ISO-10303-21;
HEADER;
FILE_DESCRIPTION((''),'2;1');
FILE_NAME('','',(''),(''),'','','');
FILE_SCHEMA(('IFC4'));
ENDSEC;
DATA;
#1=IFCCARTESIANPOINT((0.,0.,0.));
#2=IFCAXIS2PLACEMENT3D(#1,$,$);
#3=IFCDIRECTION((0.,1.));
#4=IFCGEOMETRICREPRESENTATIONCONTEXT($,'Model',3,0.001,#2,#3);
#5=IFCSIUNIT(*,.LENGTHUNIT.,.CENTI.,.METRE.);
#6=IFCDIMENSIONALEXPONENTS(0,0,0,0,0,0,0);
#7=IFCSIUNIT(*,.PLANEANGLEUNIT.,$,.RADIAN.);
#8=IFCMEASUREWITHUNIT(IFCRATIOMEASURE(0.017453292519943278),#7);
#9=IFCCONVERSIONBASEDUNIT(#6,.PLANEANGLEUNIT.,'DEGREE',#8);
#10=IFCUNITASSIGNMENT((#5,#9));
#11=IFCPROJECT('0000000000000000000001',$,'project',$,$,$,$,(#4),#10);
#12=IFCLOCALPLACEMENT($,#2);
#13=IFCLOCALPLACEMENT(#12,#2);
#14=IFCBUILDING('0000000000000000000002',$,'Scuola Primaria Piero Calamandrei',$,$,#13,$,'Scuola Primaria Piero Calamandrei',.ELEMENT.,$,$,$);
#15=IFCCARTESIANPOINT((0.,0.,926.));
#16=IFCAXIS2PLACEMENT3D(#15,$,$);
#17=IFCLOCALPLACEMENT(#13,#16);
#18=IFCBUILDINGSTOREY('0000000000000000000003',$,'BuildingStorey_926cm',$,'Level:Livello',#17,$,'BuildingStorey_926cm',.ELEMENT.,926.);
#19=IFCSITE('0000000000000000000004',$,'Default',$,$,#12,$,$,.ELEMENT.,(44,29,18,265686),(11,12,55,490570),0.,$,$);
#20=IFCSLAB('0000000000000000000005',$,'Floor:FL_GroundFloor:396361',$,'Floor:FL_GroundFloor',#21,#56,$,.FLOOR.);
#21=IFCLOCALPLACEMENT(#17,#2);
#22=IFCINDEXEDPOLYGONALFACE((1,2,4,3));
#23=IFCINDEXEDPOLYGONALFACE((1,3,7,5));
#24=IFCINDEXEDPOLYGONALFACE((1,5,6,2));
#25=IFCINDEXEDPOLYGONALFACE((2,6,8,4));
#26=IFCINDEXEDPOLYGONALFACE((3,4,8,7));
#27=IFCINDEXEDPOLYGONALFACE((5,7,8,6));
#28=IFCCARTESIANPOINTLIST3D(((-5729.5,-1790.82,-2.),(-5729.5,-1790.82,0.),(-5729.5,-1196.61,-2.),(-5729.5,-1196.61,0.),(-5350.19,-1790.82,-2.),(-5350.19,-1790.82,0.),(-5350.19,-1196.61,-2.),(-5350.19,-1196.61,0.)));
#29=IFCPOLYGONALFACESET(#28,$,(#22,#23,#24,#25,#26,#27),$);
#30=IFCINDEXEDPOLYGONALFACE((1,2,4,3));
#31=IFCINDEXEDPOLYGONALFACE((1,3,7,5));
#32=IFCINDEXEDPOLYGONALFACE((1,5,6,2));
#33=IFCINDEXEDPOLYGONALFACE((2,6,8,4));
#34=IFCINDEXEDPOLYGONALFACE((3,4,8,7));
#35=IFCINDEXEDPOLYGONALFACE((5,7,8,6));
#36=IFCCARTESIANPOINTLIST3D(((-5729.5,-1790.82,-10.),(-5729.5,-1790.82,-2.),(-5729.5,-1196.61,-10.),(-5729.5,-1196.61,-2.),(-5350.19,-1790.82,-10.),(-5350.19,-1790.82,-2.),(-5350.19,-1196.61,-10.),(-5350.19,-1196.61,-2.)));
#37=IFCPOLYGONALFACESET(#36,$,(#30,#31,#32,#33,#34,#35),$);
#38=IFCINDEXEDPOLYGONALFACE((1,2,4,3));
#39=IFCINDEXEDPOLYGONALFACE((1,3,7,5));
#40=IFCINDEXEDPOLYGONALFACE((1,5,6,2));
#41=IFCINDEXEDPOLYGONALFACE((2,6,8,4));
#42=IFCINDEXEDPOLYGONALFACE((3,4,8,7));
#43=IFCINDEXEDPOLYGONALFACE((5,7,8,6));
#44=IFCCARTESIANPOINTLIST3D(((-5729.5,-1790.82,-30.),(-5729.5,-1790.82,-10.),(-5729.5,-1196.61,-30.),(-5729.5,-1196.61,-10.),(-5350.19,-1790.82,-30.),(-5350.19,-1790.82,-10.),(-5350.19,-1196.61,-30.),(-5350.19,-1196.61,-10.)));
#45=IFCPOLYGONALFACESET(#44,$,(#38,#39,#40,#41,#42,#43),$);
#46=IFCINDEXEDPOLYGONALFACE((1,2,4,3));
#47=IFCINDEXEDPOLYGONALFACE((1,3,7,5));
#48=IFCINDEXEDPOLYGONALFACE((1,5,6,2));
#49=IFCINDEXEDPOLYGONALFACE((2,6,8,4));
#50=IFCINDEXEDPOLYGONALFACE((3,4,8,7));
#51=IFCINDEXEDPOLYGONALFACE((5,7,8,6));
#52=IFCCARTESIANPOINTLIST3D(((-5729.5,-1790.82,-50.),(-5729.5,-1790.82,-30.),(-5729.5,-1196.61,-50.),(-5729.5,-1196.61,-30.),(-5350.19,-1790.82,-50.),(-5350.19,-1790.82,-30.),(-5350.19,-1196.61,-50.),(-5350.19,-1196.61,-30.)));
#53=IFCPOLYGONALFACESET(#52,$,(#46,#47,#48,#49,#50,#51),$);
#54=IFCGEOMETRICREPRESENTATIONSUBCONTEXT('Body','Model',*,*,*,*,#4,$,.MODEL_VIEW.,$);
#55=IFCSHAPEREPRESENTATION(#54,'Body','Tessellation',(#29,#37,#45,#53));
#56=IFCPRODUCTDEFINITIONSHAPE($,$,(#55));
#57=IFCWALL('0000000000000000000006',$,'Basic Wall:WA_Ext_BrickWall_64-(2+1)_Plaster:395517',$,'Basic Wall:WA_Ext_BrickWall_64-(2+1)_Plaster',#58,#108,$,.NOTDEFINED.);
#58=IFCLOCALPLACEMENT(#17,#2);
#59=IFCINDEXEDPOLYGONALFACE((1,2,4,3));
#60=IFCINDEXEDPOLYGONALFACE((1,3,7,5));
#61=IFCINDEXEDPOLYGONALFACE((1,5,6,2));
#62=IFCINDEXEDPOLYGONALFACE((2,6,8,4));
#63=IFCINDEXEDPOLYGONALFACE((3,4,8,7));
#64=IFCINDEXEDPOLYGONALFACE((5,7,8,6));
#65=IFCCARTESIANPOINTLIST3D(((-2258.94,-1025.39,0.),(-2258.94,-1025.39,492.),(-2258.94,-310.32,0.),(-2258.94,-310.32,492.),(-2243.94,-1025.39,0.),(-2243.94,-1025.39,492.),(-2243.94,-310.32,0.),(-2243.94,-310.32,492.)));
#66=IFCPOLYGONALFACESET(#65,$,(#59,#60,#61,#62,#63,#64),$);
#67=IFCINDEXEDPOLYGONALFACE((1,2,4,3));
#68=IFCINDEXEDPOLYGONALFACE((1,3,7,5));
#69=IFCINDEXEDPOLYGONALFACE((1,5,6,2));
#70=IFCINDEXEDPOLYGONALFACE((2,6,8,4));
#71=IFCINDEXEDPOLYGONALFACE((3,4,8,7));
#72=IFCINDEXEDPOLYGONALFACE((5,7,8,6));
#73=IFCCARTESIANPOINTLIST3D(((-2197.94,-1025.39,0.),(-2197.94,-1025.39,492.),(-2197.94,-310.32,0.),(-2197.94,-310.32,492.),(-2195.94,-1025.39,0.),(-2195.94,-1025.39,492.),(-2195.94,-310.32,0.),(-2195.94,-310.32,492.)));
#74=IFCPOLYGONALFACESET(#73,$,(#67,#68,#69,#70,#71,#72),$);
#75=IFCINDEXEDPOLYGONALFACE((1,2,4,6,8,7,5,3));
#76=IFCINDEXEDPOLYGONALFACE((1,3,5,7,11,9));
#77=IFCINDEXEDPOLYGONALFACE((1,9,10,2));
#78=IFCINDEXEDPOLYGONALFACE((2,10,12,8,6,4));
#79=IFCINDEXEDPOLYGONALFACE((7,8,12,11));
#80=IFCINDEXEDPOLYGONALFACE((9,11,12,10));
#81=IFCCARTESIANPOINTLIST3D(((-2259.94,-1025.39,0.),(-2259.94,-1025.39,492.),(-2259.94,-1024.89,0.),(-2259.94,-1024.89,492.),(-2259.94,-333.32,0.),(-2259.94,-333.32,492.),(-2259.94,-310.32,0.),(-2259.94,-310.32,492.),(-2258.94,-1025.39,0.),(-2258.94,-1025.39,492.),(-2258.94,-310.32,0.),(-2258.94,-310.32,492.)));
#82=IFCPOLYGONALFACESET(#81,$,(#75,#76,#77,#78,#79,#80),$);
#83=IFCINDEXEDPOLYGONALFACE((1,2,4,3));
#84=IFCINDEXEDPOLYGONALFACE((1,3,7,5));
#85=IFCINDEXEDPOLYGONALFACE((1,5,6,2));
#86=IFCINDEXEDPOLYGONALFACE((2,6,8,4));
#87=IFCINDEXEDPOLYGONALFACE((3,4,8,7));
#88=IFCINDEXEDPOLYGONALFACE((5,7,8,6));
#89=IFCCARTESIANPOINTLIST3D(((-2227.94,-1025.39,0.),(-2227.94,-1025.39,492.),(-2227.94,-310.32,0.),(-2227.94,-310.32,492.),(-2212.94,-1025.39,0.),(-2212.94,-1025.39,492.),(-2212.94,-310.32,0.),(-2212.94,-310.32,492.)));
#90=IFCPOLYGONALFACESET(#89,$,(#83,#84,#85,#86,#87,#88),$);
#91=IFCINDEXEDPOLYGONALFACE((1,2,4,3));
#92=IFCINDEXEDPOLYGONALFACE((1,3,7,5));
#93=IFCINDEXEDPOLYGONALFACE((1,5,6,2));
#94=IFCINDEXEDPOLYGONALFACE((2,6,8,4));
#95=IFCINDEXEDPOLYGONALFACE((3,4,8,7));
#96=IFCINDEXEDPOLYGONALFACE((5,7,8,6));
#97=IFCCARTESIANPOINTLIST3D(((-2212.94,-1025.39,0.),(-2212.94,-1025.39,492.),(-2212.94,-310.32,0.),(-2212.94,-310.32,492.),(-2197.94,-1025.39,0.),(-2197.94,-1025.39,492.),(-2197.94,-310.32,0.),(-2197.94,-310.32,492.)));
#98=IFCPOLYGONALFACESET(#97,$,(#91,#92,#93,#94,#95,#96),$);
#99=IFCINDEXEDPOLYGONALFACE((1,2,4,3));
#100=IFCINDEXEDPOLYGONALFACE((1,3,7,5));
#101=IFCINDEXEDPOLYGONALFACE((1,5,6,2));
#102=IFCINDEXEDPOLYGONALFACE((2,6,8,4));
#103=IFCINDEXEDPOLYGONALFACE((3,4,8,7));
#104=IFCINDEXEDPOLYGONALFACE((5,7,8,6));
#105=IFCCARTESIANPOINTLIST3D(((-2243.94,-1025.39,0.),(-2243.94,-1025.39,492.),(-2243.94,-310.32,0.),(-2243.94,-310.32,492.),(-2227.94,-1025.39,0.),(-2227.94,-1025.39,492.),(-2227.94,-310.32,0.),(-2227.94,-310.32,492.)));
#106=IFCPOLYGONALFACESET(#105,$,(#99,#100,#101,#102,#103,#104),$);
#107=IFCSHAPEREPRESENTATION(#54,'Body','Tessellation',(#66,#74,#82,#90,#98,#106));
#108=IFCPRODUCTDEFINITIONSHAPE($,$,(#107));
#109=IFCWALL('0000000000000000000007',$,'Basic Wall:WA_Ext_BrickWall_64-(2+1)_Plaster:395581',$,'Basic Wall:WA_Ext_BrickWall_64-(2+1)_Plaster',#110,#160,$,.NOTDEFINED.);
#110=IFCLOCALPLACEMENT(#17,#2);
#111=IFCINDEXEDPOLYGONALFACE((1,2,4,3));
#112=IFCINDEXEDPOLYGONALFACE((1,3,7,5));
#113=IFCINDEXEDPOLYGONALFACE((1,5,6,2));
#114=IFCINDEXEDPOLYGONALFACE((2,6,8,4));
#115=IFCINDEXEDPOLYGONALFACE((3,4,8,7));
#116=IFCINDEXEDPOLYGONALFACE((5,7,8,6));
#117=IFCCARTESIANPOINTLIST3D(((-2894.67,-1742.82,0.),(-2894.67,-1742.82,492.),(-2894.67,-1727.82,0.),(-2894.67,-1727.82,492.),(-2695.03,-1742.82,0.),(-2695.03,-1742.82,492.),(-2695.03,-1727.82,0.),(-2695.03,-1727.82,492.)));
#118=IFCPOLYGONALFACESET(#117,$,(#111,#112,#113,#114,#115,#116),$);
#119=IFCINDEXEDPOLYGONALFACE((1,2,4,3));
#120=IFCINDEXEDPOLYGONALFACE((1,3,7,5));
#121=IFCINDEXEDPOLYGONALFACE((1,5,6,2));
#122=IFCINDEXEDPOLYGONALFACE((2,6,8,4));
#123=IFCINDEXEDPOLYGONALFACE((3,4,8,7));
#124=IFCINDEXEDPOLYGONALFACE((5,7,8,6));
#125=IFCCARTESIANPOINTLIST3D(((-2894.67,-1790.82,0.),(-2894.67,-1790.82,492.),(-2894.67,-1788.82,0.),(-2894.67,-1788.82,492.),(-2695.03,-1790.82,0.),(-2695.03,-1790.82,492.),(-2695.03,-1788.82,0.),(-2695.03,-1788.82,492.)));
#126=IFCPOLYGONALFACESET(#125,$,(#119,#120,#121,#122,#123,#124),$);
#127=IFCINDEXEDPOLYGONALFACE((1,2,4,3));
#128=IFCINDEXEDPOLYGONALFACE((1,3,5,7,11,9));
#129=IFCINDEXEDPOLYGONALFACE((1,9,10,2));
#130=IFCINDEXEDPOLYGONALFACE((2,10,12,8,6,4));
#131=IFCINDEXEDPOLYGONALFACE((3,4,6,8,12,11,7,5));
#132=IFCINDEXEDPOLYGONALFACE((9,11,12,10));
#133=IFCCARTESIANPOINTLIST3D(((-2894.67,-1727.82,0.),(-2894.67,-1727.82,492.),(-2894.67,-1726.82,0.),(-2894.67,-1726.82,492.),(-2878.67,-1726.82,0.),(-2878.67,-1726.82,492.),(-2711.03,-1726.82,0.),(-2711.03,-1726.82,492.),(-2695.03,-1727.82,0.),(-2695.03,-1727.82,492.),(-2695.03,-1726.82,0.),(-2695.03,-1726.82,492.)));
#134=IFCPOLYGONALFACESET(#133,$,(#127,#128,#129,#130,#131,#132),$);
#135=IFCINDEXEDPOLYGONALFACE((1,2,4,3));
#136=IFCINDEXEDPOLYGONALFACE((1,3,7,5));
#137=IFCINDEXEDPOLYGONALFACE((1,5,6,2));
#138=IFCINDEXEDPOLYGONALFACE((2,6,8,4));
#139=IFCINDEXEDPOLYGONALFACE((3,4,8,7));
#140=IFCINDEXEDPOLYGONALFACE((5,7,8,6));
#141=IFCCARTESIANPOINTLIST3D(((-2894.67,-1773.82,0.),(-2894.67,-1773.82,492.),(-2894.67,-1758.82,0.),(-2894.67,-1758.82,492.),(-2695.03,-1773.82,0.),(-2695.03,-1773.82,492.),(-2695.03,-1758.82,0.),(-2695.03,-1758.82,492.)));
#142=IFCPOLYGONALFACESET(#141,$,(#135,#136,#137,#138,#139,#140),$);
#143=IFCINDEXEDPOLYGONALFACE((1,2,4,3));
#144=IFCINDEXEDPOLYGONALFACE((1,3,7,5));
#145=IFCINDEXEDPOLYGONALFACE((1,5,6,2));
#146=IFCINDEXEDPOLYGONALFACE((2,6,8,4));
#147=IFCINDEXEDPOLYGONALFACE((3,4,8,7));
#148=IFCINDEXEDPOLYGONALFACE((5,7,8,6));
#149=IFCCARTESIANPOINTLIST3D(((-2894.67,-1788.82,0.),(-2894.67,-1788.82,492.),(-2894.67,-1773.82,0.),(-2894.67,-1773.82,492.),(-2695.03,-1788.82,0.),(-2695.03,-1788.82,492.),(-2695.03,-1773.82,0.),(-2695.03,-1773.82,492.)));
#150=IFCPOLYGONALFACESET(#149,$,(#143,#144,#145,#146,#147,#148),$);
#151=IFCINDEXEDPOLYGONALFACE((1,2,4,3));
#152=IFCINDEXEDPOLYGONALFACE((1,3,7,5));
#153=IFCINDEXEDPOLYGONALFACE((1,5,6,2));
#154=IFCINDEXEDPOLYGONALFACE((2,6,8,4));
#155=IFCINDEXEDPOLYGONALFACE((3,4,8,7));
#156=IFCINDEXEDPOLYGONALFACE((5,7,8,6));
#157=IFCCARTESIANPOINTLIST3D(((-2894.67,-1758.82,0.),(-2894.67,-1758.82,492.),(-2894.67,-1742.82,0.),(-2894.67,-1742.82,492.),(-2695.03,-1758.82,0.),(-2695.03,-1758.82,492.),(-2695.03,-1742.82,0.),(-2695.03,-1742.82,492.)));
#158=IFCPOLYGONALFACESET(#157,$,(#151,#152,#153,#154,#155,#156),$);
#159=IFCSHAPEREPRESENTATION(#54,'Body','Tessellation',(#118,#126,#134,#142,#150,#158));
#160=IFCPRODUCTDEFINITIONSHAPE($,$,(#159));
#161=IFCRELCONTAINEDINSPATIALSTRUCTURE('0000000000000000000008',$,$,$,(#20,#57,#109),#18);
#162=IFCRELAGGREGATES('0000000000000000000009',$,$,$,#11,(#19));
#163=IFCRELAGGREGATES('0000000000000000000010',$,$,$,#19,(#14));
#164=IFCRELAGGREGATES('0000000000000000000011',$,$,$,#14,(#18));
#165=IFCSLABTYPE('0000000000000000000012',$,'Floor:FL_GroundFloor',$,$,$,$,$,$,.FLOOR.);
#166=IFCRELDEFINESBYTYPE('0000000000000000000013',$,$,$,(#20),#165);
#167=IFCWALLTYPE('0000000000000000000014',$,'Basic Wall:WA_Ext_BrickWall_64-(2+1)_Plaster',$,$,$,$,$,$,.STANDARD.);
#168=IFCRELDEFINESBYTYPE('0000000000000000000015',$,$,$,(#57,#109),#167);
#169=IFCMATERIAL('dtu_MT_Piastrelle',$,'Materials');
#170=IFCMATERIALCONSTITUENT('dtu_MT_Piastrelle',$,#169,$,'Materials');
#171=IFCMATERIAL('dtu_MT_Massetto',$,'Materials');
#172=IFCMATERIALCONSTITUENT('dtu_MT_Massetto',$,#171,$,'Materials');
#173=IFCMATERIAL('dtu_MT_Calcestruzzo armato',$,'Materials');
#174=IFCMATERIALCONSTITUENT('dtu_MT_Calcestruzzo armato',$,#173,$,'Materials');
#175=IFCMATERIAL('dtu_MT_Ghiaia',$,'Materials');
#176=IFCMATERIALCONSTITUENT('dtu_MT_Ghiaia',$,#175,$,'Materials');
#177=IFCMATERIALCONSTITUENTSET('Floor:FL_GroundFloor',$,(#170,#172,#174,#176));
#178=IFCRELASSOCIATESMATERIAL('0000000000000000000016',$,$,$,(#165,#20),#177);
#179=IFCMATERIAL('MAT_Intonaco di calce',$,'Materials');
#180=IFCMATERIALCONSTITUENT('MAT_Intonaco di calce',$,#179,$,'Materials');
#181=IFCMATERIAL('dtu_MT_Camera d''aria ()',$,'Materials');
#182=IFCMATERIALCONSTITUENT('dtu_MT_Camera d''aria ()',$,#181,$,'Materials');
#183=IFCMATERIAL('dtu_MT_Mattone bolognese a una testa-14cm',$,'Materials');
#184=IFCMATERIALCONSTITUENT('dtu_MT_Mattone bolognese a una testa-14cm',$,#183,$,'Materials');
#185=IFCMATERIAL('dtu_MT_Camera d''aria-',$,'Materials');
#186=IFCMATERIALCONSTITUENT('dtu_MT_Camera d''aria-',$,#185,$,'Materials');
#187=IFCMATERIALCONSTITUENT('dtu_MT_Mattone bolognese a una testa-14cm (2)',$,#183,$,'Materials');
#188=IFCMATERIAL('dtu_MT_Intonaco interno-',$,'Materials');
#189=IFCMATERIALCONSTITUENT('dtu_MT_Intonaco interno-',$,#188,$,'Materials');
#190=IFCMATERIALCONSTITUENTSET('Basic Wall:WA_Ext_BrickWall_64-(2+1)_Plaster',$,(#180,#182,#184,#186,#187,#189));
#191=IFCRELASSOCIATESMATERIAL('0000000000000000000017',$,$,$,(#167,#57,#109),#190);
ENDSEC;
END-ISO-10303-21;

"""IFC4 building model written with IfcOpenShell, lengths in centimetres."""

from ifc_helpers import new_model, entity, si_unit, converted_unit, direction, frame, origin, place, context, subcontext, project, spatial, indexed_curve, outline, extrude, material, constituent, constituent_set, type_object, element, save


model = new_model("IFC4")

# Units and contexts
model_context = context("Model", 3, precision=0.001, world=origin(), true_north=direction((0.0, 1.0)))
body_context = subcontext(model_context, "Body", "Model", "MODEL_VIEW")
ifc_project = project(units=[si_unit("LENGTHUNIT", "METRE", prefix="CENTI"), converted_unit("PLANEANGLEUNIT", "DEGREE", entity("IfcRatioMeasure", 0.017453292519943278), si_unit("PLANEANGLEUNIT", "RADIAN"), dimensions=[0, 0, 0, 0, 0, 0, 0])], contexts=[model_context])

# Site, building, storey
site_placement = place(None, origin())
site = spatial("IfcSite", under=ifc_project, at=site_placement, Name="Default", CompositionType="ELEMENT", RefLatitude=(44, 29, 18, 265686), RefLongitude=(11, 12, 55, 490570), RefElevation=0.0)
building_placement = place(site_placement, origin())
building = spatial("IfcBuilding", under=site, at=building_placement, Name="Scuola Primaria Piero Calamandrei", LongName="Scuola Primaria Piero Calamandrei", CompositionType="ELEMENT")
storey_placement = place(building_placement, frame((0.0, 0.0, 926.0)))
storey = spatial("IfcBuildingStorey", under=building, at=storey_placement, Name="BuildingStorey_926cm", ObjectType="Level:Livello", LongName="BuildingStorey_926cm", CompositionType="ELEMENT", Elevation=926.0)

# Slab
ifc_material_1 = material(Name="dtu_MT_Piastrelle", Category="Materials")
ifc_constituent_1 = constituent(ifc_material_1, Name="dtu_MT_Piastrelle", Category="Materials")
ifc_material_2 = material(Name="dtu_MT_Massetto", Category="Materials")
ifc_constituent_2 = constituent(ifc_material_2, Name="dtu_MT_Massetto", Category="Materials")
ifc_material_3 = material(Name="dtu_MT_Calcestruzzo armato", Category="Materials")
ifc_constituent_3 = constituent(ifc_material_3, Name="dtu_MT_Calcestruzzo armato", Category="Materials")
ifc_material_4 = material(Name="dtu_MT_Ghiaia", Category="Materials")
ifc_constituent_4 = constituent(ifc_material_4, Name="dtu_MT_Ghiaia", Category="Materials")
ifc_constituent_set_1 = constituent_set(constituents=[ifc_constituent_1, ifc_constituent_2, ifc_constituent_3, ifc_constituent_4], Name="Floor:FL_GroundFloor")
slab_type_1 = type_object("IfcSlabType", Name="Floor:FL_GroundFloor", PredefinedType="FLOOR", material=ifc_constituent_set_1)
slab_1_placement = place(storey_placement, origin())
element("IfcSlab", 1, at=slab_1_placement, inside=storey, type_object=slab_type_1, material=ifc_constituent_set_1, Name="Floor:FL_GroundFloor:396361", ObjectType="Floor:FL_GroundFloor", PredefinedType="FLOOR", context=body_context, shape_type="SweptSolid", body=[
    extrude(outline(indexed_curve([(-297.11, -189.65), (297.11, -189.65), (297.11, 189.65), (-297.11, 189.65), (-297.11, -189.65)], self_intersect=False)), frame((-5539.85, -1493.71, -2.0), z_axis=(0.0, 0.0, 1.0), x_axis=(0.0, 1.0, 0.0)), (0.0, 0.0, 1.0), 2.0),
    extrude(outline(indexed_curve([(-297.11, -189.65), (297.11, -189.65), (297.11, 189.65), (-297.11, 189.65), (-297.11, -189.65)], self_intersect=False)), frame((-5539.85, -1493.71, -10.0), z_axis=(0.0, 0.0, 1.0), x_axis=(0.0, 1.0, 0.0)), (0.0, 0.0, 1.0), 8.0),
    extrude(outline(indexed_curve([(-297.11, -189.65), (297.11, -189.65), (297.11, 189.65), (-297.11, 189.65), (-297.11, -189.65)], self_intersect=False)), frame((-5539.85, -1493.71, -30.0), z_axis=(0.0, 0.0, 1.0), x_axis=(0.0, 1.0, 0.0)), (0.0, 0.0, 1.0), 20.0),
    extrude(outline(indexed_curve([(-297.11, -189.65), (297.11, -189.65), (297.11, 189.65), (-297.11, 189.65), (-297.11, -189.65)], self_intersect=False)), frame((-5539.85, -1493.71, -50.0), z_axis=(0.0, 0.0, 1.0), x_axis=(0.0, 1.0, 0.0)), (0.0, 0.0, 1.0), 20.0),
])

# Walls
ifc_material_5 = material(Name="MAT_Intonaco di calce", Category="Materials")
ifc_constituent_5 = constituent(ifc_material_5, Name="MAT_Intonaco di calce", Category="Materials")
ifc_material_6 = material(Name="dtu_MT_Camera d'aria ()", Category="Materials")
ifc_constituent_6 = constituent(ifc_material_6, Name="dtu_MT_Camera d'aria ()", Category="Materials")
ifc_material_7 = material(Name="dtu_MT_Mattone bolognese a una testa-14cm", Category="Materials")
ifc_constituent_7 = constituent(ifc_material_7, Name="dtu_MT_Mattone bolognese a una testa-14cm", Category="Materials")
ifc_material_8 = material(Name="dtu_MT_Camera d'aria-", Category="Materials")
ifc_constituent_8 = constituent(ifc_material_8, Name="dtu_MT_Camera d'aria-", Category="Materials")
ifc_constituent_9 = constituent(ifc_material_7, Name="dtu_MT_Mattone bolognese a una testa-14cm (2)", Category="Materials")
ifc_material_9 = material(Name="dtu_MT_Intonaco interno-", Category="Materials")
ifc_constituent_10 = constituent(ifc_material_9, Name="dtu_MT_Intonaco interno-", Category="Materials")
ifc_constituent_set_2 = constituent_set(constituents=[ifc_constituent_5, ifc_constituent_6, ifc_constituent_7, ifc_constituent_8, ifc_constituent_9, ifc_constituent_10], Name="Basic Wall:WA_Ext_BrickWall_64-(2+1)_Plaster")
wall_type_1 = type_object("IfcWallType", Name="Basic Wall:WA_Ext_BrickWall_64-(2+1)_Plaster", PredefinedType="STANDARD", material=ifc_constituent_set_2)
wall_1_placement = place(storey_placement, frame((-2227.94, -310.32, 0.0), z_axis=(0.0, 0.0, 1.0), x_axis=(0.0, -1.0, 0.0)))
element("IfcWall", 2, at=wall_1_placement, inside=storey, type_object=wall_type_1, material=ifc_constituent_set_2, Name="Basic Wall:WA_Ext_BrickWall_64-(2+1)_Plaster:395517", ObjectType="Basic Wall:WA_Ext_BrickWall_64-(2+1)_Plaster", PredefinedType="NOTDEFINED", context=body_context, shape_type="SweptSolid", body=[
    extrude(outline(indexed_curve([(-357.54, -7.5), (357.54, -7.5), (357.54, 7.5), (-357.54, 7.5), (-357.54, -7.5)], self_intersect=False)), frame((357.54, -23.5, 0.0)), (0.0, 0.0, 1.0), 492.0),
    extrude(outline(indexed_curve([(-1.0, -357.54), (1.0, -357.54), (1.0, 357.54), (-1.0, 357.54), (-1.0, -357.54)], self_intersect=False)), frame((357.54, 31.0, 0.0), z_axis=(0.0, 0.0, 1.0), x_axis=(0.0, -1.0, 0.0)), (0.0, 0.0, 1.0), 492.0),
    extrude(outline(indexed_curve([(-338.29, -0.33), (353.29, -0.33), (353.79, -0.33), (353.79, 0.67), (-361.29, 0.67), (-361.29, -0.33), (-338.29, -0.33)], self_intersect=False)), frame((361.29, -31.67, 0.0)), (0.0, 0.0, 1.0), 492.0),
    extrude(outline(indexed_curve([(-357.54, -7.5), (357.54, -7.5), (357.54, 7.5), (-357.54, 7.5), (-357.54, -7.5)], self_intersect=False)), frame((357.54, 7.5, 0.0)), (0.0, 0.0, 1.0), 492.0),
    extrude(outline(indexed_curve([(-357.54, -7.5), (357.54, -7.5), (357.54, 7.5), (-357.54, 7.5), (-357.54, -7.5)], self_intersect=False)), frame((357.54, 22.5, 0.0)), (0.0, 0.0, 1.0), 492.0),
    extrude(outline(indexed_curve([(-357.54, -8.0), (357.54, -8.0), (357.54, 8.0), (-357.54, 8.0), (-357.54, -8.0)], self_intersect=False)), frame((357.54, -8.0, 0.0)), (0.0, 0.0, 1.0), 492.0),
])
wall_2_placement = place(storey_placement, frame((-2695.03, -1758.82, 0.0), z_axis=(0.0, 0.0, 1.0), x_axis=(-1.0, 0.0, 0.0)))
element("IfcWall", 3, at=wall_2_placement, inside=storey, type_object=wall_type_1, material=ifc_constituent_set_2, Name="Basic Wall:WA_Ext_BrickWall_64-(2+1)_Plaster:395581", ObjectType="Basic Wall:WA_Ext_BrickWall_64-(2+1)_Plaster", PredefinedType="NOTDEFINED", context=body_context, shape_type="SweptSolid", body=[
    extrude(outline(indexed_curve([(-99.82, -7.5), (99.82, -7.5), (99.82, 7.5), (-99.82, 7.5), (-99.82, -7.5)], self_intersect=False)), frame((99.82, -23.5, 0.0)), (0.0, 0.0, 1.0), 492.0),
    extrude(outline(indexed_curve([(-1.0, -99.82), (1.0, -99.82), (1.0, 99.82), (-1.0, 99.82), (-1.0, -99.82)], self_intersect=False)), frame((99.82, 31.0, 0.0), z_axis=(0.0, 0.0, 1.0), x_axis=(0.0, -1.0, 0.0)), (0.0, 0.0, 1.0), 492.0),
    extrude(outline(indexed_curve([(-83.82, -0.33), (83.82, -0.33), (99.82, -0.33), (99.82, 0.67), (-99.82, 0.67), (-99.82, -0.33), (-83.82, -0.33)], self_intersect=False)), frame((99.82, -31.67, 0.0)), (0.0, 0.0, 1.0), 492.0),
    extrude(outline(indexed_curve([(-99.82, -7.5), (99.82, -7.5), (99.82, 7.5), (-99.82, 7.5), (-99.82, -7.5)], self_intersect=False)), frame((99.82, 7.5, 0.0)), (0.0, 0.0, 1.0), 492.0),
    extrude(outline(indexed_curve([(-99.82, -7.5), (99.82, -7.5), (99.82, 7.5), (-99.82, 7.5), (-99.82, -7.5)], self_intersect=False)), frame((99.82, 22.5, 0.0)), (0.0, 0.0, 1.0), 492.0),
    extrude(outline(indexed_curve([(-99.82, -8.0), (99.82, -8.0), (99.82, 8.0), (-99.82, 8.0), (-99.82, -8.0)], self_intersect=False)), frame((99.82, -8.0, 0.0)), (0.0, 0.0, 1.0), 492.0),
])

save(model, "model.ifc")
